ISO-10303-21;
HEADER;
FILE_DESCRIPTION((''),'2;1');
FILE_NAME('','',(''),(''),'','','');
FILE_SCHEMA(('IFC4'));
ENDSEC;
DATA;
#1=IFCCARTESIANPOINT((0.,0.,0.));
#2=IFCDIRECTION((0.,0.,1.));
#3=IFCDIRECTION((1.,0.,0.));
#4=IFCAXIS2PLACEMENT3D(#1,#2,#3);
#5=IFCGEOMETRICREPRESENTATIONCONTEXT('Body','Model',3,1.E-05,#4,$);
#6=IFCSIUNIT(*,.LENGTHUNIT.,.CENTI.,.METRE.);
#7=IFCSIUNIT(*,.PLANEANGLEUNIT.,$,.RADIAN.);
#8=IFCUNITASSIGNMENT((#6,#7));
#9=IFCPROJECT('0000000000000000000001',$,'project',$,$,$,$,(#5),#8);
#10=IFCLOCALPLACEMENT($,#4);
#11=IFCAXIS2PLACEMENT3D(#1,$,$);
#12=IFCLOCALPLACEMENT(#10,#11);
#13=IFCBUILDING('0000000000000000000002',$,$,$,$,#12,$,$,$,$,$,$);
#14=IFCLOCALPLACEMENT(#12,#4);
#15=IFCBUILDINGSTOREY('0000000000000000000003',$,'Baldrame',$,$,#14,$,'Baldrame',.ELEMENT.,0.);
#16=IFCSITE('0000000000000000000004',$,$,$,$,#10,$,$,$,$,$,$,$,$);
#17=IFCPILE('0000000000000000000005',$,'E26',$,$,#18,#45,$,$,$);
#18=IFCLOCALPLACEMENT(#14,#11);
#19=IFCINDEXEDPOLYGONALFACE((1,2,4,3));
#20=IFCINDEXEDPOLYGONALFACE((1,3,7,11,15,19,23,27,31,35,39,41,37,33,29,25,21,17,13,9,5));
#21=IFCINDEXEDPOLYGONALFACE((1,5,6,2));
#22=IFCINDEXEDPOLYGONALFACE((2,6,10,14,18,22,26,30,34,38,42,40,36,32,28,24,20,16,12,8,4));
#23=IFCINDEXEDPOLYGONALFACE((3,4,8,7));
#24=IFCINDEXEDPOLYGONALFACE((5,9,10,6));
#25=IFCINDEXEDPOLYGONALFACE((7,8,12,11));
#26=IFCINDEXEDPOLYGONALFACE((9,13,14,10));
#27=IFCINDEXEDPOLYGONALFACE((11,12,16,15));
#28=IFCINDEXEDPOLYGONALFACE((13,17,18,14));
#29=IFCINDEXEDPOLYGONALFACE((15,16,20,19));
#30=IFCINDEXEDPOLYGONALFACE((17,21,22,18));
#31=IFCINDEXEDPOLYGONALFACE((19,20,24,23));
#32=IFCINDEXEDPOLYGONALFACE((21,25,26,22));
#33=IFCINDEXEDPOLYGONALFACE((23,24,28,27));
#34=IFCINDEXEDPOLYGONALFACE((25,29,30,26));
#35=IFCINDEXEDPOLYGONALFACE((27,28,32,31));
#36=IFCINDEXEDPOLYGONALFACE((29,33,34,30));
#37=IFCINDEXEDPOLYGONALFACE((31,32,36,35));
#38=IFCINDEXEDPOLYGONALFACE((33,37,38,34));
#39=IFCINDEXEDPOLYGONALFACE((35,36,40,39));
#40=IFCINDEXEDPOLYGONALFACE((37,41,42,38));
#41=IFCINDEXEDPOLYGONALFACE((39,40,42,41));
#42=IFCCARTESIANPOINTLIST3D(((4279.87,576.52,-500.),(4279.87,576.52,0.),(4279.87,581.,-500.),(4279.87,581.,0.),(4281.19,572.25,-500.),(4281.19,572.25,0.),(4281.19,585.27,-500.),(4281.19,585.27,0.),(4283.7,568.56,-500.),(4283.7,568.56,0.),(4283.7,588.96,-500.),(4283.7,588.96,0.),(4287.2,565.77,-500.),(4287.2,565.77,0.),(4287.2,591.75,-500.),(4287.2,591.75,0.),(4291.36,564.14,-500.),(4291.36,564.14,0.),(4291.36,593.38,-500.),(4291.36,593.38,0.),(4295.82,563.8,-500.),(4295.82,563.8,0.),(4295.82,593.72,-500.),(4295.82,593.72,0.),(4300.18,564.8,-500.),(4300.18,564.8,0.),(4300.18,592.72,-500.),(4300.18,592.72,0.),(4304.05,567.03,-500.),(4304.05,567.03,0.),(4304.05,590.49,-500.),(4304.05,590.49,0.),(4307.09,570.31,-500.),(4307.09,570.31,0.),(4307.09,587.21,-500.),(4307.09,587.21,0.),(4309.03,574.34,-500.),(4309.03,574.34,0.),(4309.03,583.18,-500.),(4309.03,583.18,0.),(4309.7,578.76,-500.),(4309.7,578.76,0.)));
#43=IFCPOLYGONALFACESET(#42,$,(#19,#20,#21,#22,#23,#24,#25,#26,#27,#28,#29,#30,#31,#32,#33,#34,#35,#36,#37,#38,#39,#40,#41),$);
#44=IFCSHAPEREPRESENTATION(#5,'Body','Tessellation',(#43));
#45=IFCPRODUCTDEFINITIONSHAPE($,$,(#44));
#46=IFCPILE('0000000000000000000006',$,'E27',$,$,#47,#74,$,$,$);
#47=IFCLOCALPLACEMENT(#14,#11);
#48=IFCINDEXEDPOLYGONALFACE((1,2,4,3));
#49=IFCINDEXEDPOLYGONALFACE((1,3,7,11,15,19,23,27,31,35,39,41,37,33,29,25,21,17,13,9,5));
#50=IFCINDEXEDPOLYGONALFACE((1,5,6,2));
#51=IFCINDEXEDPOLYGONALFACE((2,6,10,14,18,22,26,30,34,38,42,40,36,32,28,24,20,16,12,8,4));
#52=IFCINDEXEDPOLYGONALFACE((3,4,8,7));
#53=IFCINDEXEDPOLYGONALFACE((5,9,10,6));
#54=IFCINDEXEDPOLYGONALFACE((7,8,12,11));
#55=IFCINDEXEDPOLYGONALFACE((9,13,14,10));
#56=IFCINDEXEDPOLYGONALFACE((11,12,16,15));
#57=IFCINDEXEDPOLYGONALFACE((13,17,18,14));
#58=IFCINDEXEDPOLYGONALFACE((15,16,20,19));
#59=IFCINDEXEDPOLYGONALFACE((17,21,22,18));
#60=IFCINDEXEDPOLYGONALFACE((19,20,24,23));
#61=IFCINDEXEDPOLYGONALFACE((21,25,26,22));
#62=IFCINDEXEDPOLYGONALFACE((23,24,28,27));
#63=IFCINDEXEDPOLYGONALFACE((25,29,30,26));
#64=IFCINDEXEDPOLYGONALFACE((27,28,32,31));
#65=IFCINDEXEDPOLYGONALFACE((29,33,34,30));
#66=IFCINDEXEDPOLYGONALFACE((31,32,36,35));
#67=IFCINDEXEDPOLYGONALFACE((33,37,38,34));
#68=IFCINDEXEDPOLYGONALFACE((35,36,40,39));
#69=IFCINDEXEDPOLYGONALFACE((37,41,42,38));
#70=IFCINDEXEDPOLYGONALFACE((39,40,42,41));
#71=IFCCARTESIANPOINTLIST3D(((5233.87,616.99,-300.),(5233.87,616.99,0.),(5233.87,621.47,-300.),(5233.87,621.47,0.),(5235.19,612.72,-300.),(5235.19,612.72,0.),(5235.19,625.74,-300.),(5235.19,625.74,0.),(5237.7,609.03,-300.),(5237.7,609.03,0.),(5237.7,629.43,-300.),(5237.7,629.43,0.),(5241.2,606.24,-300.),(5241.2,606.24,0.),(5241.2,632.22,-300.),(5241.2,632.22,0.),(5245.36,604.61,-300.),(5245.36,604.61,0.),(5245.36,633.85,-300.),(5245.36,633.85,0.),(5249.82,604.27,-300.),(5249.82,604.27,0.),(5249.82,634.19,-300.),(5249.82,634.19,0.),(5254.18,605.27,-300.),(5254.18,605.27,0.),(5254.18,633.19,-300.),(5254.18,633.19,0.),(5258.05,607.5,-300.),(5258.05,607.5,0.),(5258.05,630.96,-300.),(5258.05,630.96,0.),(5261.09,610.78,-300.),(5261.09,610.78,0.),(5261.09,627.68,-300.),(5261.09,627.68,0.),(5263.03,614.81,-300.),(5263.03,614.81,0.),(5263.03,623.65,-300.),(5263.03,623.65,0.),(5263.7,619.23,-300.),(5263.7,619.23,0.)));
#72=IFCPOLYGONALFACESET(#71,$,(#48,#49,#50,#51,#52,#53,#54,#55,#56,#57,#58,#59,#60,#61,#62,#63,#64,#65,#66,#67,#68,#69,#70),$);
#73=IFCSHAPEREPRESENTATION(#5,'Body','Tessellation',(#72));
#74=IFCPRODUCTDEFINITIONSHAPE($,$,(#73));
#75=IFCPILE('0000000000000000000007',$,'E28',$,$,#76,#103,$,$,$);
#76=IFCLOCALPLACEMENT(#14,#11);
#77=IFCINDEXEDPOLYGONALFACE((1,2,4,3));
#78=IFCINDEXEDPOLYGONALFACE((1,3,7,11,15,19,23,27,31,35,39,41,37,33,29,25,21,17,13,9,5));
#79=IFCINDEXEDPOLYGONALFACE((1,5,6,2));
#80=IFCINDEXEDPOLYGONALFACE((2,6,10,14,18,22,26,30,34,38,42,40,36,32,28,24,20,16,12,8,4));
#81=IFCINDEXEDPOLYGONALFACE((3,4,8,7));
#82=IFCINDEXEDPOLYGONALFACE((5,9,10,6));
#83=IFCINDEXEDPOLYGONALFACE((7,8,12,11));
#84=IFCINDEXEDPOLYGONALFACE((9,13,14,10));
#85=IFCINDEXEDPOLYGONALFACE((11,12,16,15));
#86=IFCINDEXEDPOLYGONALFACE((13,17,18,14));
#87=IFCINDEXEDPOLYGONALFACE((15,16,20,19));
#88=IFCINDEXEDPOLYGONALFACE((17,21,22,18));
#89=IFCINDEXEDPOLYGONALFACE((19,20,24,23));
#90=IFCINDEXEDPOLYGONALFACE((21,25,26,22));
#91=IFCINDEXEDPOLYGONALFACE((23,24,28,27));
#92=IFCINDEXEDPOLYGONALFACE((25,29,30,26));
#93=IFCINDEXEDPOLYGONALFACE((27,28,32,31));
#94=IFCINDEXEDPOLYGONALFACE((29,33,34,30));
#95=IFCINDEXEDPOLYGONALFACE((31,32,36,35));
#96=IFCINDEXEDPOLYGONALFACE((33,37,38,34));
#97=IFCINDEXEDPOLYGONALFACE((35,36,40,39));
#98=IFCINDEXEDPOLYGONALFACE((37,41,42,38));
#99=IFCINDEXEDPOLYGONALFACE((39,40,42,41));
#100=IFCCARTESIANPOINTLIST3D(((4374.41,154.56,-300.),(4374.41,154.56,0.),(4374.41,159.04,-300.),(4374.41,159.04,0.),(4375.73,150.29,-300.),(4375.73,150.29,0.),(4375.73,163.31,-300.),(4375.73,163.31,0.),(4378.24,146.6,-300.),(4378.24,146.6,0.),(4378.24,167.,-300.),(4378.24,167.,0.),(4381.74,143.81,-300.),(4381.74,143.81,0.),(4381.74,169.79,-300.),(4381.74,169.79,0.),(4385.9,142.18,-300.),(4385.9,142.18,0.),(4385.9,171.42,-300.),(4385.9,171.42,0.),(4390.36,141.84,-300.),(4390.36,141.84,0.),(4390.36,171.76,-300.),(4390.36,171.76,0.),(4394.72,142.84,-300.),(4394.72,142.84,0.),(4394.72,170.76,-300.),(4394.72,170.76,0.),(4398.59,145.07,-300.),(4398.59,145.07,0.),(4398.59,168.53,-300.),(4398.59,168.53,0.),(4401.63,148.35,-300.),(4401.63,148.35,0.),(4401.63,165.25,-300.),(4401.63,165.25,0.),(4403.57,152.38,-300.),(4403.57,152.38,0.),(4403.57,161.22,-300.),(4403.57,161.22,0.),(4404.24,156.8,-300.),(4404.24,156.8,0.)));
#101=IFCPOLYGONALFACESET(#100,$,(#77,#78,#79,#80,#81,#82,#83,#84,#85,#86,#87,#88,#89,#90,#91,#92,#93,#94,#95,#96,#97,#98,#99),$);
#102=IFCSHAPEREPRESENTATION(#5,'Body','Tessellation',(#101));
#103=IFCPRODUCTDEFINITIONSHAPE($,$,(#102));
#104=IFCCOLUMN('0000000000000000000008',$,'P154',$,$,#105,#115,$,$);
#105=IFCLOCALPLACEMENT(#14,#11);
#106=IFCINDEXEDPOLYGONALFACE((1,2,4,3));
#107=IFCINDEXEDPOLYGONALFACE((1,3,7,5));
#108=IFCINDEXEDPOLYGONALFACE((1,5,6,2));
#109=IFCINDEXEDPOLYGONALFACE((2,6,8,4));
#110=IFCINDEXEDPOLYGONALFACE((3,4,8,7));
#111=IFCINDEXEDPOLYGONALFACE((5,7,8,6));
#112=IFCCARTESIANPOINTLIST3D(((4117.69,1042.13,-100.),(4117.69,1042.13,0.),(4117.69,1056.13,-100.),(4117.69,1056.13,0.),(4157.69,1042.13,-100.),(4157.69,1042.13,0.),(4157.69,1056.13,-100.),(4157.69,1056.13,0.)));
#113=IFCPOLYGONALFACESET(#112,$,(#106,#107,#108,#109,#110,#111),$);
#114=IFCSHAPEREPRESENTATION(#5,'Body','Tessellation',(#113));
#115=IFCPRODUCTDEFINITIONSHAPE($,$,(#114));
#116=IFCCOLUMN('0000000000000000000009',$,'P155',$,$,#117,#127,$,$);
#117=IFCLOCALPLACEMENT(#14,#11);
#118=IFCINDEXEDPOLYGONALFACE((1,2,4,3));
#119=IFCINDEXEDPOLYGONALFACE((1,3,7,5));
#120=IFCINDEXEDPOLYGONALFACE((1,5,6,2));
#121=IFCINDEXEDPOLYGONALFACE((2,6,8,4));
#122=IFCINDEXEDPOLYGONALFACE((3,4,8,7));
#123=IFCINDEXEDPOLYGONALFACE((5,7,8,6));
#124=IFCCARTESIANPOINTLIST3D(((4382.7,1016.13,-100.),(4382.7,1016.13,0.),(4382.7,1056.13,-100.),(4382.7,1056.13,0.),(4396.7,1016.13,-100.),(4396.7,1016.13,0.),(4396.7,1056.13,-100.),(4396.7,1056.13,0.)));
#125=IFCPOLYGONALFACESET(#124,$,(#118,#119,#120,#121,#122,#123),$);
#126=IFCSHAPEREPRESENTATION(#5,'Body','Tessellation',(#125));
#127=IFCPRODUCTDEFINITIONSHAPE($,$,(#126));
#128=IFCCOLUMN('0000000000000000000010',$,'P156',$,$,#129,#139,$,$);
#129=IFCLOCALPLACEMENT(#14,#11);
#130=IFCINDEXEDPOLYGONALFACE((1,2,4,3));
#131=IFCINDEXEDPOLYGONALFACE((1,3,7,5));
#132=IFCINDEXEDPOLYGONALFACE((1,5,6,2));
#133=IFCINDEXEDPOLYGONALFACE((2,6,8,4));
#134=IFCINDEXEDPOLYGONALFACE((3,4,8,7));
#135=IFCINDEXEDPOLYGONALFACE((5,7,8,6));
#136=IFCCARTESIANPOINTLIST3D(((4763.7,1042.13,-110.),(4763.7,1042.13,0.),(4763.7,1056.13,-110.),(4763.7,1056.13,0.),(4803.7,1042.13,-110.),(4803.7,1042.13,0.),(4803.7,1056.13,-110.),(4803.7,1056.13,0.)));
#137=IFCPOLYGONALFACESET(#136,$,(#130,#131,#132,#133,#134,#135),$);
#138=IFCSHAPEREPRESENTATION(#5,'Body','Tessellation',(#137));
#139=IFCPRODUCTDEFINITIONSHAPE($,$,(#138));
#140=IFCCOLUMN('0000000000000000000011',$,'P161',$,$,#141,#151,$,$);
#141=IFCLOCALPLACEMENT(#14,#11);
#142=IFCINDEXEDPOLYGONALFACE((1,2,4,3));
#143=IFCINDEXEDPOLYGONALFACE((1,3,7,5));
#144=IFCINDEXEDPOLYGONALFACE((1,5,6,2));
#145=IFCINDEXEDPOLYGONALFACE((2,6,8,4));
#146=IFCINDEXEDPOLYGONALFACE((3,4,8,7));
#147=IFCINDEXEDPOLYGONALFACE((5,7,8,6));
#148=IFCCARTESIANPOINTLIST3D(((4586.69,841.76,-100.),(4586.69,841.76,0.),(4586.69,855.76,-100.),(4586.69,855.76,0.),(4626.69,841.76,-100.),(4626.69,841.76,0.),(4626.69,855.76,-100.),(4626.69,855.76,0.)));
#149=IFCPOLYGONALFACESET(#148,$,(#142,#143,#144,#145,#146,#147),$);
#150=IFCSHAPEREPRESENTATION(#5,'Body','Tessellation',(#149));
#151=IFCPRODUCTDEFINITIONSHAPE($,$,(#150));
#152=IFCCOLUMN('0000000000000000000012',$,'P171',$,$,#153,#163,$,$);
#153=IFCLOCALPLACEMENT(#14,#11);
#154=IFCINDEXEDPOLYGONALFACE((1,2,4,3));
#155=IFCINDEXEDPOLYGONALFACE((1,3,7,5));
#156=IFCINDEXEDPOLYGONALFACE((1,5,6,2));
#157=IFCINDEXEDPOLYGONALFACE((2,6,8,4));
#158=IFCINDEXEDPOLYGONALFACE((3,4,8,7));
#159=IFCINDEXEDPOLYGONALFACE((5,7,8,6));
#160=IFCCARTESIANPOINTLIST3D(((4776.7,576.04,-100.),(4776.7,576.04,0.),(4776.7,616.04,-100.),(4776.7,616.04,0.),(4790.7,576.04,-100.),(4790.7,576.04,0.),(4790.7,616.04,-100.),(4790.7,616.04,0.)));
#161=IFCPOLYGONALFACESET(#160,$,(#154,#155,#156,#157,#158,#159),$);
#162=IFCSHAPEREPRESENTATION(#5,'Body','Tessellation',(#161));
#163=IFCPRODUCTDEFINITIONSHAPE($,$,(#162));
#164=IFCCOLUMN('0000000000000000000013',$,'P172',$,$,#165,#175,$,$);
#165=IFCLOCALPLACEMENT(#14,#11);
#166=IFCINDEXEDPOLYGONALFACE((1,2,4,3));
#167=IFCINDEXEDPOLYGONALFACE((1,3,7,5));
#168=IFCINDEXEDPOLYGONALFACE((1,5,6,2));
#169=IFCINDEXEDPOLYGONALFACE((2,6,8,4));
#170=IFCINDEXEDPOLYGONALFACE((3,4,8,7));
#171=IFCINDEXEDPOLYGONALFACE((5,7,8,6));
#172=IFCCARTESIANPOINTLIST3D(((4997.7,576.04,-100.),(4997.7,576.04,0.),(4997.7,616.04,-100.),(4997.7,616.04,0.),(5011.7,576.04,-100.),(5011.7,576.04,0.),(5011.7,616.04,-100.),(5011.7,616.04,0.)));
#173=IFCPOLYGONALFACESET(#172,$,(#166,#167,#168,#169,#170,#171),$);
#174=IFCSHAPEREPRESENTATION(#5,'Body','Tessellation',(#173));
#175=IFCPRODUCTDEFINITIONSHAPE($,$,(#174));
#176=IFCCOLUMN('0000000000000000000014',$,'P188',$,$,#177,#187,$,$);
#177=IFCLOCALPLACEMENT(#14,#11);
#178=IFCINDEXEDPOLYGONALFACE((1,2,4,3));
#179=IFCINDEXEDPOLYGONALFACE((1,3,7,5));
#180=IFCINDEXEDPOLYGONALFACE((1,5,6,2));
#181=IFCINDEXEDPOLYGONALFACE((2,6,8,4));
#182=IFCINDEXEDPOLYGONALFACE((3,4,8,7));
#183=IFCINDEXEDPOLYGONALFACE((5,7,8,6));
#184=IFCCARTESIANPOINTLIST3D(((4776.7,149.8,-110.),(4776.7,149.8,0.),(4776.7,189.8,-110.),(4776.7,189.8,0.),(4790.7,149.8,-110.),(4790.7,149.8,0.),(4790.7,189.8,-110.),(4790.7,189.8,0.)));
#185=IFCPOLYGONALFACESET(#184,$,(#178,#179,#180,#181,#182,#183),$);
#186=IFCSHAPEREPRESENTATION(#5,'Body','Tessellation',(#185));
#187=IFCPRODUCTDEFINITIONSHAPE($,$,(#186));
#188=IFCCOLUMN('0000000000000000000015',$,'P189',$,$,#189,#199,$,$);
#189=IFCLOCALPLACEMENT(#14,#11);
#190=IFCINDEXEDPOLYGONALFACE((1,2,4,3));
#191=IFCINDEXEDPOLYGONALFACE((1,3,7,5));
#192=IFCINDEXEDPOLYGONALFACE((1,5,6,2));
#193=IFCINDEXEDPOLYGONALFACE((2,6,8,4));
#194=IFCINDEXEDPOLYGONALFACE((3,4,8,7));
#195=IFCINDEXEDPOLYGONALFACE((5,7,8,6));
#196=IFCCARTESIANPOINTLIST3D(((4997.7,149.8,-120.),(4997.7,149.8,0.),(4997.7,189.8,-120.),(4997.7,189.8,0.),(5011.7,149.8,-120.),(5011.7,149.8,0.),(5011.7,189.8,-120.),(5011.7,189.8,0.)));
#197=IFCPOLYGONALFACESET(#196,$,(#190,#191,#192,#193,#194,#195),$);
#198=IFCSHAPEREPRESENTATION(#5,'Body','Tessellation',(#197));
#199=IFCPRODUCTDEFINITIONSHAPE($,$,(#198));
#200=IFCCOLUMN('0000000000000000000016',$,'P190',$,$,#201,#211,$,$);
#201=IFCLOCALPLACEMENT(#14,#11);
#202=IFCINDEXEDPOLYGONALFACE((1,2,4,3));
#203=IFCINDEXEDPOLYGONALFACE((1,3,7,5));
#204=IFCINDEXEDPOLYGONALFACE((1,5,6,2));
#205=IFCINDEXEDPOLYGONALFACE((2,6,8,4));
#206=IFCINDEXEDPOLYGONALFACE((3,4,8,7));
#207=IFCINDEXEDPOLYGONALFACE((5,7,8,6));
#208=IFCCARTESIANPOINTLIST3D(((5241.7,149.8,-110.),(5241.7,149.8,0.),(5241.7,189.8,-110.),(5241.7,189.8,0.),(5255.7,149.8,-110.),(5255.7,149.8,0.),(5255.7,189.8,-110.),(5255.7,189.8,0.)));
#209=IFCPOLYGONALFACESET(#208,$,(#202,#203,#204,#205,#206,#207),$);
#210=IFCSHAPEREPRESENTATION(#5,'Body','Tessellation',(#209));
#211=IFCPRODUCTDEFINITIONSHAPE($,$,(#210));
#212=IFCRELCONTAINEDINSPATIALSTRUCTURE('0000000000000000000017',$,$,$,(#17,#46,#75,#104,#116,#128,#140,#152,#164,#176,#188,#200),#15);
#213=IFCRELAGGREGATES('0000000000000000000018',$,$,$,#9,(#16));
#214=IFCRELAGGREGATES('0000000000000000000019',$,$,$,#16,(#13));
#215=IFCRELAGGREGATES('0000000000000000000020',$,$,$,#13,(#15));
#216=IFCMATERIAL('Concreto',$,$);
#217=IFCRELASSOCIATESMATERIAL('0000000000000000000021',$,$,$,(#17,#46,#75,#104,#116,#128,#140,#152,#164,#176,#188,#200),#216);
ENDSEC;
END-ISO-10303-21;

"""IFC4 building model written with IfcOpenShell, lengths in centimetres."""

from ifc_helpers import new_model, si_unit, frame, origin, origin_with_axes, origin_2d_with_axis, place, context, project, spatial, rectangle, circle, extrude, material, element, save


model = new_model("IFC4")

# Units and contexts
model_context = context("Model", 3, precision=1e-05, world=origin_with_axes(), identifier="Body")
ifc_project = project(units=[si_unit("LENGTHUNIT", "METRE", prefix="CENTI"), si_unit("PLANEANGLEUNIT", "RADIAN")], contexts=[model_context])

# Site, building, storey
site_placement = place(None, origin_with_axes())
site = spatial("IfcSite", under=ifc_project, at=site_placement)
building_placement = place(site_placement, origin())
building = spatial("IfcBuilding", under=site, at=building_placement)
storey_placement = place(building_placement, origin_with_axes())
storey = spatial("IfcBuildingStorey", under=building, at=storey_placement, Name="Baldrame", LongName="Baldrame", CompositionType="ELEMENT", Elevation=0.0)

# Piles
ifc_material = material(Name="Concreto")
pile_placement = place(storey_placement, frame((4294.7, 578.76, 0.0), z_axis=(0.0, 0.0, 1.0), x_axis=(1.0, 0.0, 0.0)))
element("IfcPile", 1, at=pile_placement, inside=storey, material=ifc_material, Name="E26", context=model_context, shape_type="SolidModel", body=[
    extrude(circle(Radius=15.0, at=origin_2d_with_axis()), frame((0.0, 0.0, -500.0), z_axis=(0.0, 0.0, 1.0), x_axis=(1.0, 0.0, 0.0)), (0.0, 0.0, 1.0), 500.0),
])
for number, where, z_axis, x_axis, name in (
    (2, (5248.7, 619.23, 0.0), (0.0, 0.0, 1.0), (1.0, 0.0, 0.0), "E27"),
    (3, (4389.24, 156.8, 0.0), (0.0, 0.0, 1.0), (1.0, 0.0, 0.0), "E28"),
):
    element("IfcPile", number, at=place(storey_placement, frame(where, z_axis=z_axis, x_axis=x_axis)), inside=storey, material=ifc_material, Name=name, context=model_context, shape_type="SolidModel", body=[
        extrude(circle(Radius=15.0, at=origin_2d_with_axis()), frame((0.0, 0.0, -300.0), z_axis=(0.0, 0.0, 1.0), x_axis=(1.0, 0.0, 0.0)), (0.0, 0.0, 1.0), 300.0),
    ])

# Columns
column_1_placement = place(storey_placement, frame((4137.69, 1049.13, 0.0), z_axis=(0.0, 0.0, 1.0), x_axis=(1.0, 0.0, 0.0)))
element("IfcColumn", 4, at=column_1_placement, inside=storey, material=ifc_material, Name="P154", context=model_context, shape_type="SolidModel", body=[
    extrude(rectangle(XDim=14.0, YDim=40.0, at=origin_2d_with_axis()), frame((0.0, 0.0, -100.0), z_axis=(0.0, 0.0, 1.0), x_axis=(0.0, -1.0, 0.0)), (0.0, 0.0, 1.0), 100.0),
])
column_2_placement = place(storey_placement, frame((4389.7, 1036.13, 0.0), z_axis=(0.0, 0.0, 1.0), x_axis=(1.0, 0.0, 0.0)))
element("IfcColumn", 5, at=column_2_placement, inside=storey, material=ifc_material, Name="P155", context=model_context, shape_type="SolidModel", body=[
    extrude(rectangle(XDim=14.0, YDim=40.0, at=origin_2d_with_axis()), frame((0.0, 0.0, -100.0), z_axis=(0.0, 0.0, 1.0), x_axis=(-1.0, 0.0, 0.0)), (0.0, 0.0, 1.0), 100.0),
])
column_3_placement = place(storey_placement, frame((4783.7, 1049.13, 0.0), z_axis=(0.0, 0.0, 1.0), x_axis=(1.0, 0.0, 0.0)))
element("IfcColumn", 6, at=column_3_placement, inside=storey, material=ifc_material, Name="P156", context=model_context, shape_type="SolidModel", body=[
    extrude(rectangle(XDim=14.0, YDim=40.0, at=origin_2d_with_axis()), frame((0.0, 0.0, -110.0), z_axis=(0.0, 0.0, 1.0), x_axis=(0.0, -1.0, 0.0)), (0.0, 0.0, 1.0), 110.0),
])
column_4_placement = place(storey_placement, frame((4606.69, 848.76, 0.0), z_axis=(0.0, 0.0, 1.0), x_axis=(1.0, 0.0, 0.0)))
element("IfcColumn", 7, at=column_4_placement, inside=storey, material=ifc_material, Name="P161", context=model_context, shape_type="SolidModel", body=[
    extrude(rectangle(XDim=14.0, YDim=40.0, at=origin_2d_with_axis()), frame((0.0, 0.0, -100.0), z_axis=(0.0, 0.0, 1.0), x_axis=(0.0, -1.0, 0.0)), (0.0, 0.0, 1.0), 100.0),
])
for number, where, z_axis, x_axis, name in (
    (8, (4783.7, 596.04, 0.0), (0.0, 0.0, 1.0), (1.0, 0.0, 0.0), "P171"),
    (9, (5004.7, 596.04, 0.0), (0.0, 0.0, 1.0), (1.0, 0.0, 0.0), "P172"),
):
    element("IfcColumn", number, at=place(storey_placement, frame(where, z_axis=z_axis, x_axis=x_axis)), inside=storey, material=ifc_material, Name=name, context=model_context, shape_type="SolidModel", body=[
        extrude(rectangle(XDim=14.0, YDim=40.0, at=origin_2d_with_axis()), frame((0.0, 0.0, -100.0), z_axis=(0.0, 0.0, 1.0), x_axis=(-1.0, 0.0, 0.0)), (0.0, 0.0, 1.0), 100.0),
    ])
column_5_placement = place(storey_placement, frame((4783.7, 169.8, 0.0), z_axis=(0.0, 0.0, 1.0), x_axis=(1.0, 0.0, 0.0)))
element("IfcColumn", 10, at=column_5_placement, inside=storey, material=ifc_material, Name="P188", context=model_context, shape_type="SolidModel", body=[
    extrude(rectangle(XDim=14.0, YDim=40.0, at=origin_2d_with_axis()), frame((0.0, 0.0, -110.0), z_axis=(0.0, 0.0, 1.0), x_axis=(-1.0, 0.0, 0.0)), (0.0, 0.0, 1.0), 110.0),
])
column_6_placement = place(storey_placement, frame((5004.7, 169.8, 0.0), z_axis=(0.0, 0.0, 1.0), x_axis=(1.0, 0.0, 0.0)))
element("IfcColumn", 11, at=column_6_placement, inside=storey, material=ifc_material, Name="P189", context=model_context, shape_type="SolidModel", body=[
    extrude(rectangle(XDim=14.0, YDim=40.0, at=origin_2d_with_axis()), frame((0.0, 0.0, -120.0), z_axis=(0.0, 0.0, 1.0), x_axis=(-1.0, 0.0, 0.0)), (0.0, 0.0, 1.0), 120.0),
])
column_7_placement = place(storey_placement, frame((5248.7, 169.8, 0.0), z_axis=(0.0, 0.0, 1.0), x_axis=(1.0, 0.0, 0.0)))
element("IfcColumn", 12, at=column_7_placement, inside=storey, material=ifc_material, Name="P190", context=model_context, shape_type="SolidModel", body=[
    extrude(rectangle(XDim=14.0, YDim=40.0, at=origin_2d_with_axis()), frame((0.0, 0.0, -110.0), z_axis=(0.0, 0.0, 1.0), x_axis=(-1.0, 0.0, 0.0)), (0.0, 0.0, 1.0), 110.0),
])

save(model, "model.ifc")
